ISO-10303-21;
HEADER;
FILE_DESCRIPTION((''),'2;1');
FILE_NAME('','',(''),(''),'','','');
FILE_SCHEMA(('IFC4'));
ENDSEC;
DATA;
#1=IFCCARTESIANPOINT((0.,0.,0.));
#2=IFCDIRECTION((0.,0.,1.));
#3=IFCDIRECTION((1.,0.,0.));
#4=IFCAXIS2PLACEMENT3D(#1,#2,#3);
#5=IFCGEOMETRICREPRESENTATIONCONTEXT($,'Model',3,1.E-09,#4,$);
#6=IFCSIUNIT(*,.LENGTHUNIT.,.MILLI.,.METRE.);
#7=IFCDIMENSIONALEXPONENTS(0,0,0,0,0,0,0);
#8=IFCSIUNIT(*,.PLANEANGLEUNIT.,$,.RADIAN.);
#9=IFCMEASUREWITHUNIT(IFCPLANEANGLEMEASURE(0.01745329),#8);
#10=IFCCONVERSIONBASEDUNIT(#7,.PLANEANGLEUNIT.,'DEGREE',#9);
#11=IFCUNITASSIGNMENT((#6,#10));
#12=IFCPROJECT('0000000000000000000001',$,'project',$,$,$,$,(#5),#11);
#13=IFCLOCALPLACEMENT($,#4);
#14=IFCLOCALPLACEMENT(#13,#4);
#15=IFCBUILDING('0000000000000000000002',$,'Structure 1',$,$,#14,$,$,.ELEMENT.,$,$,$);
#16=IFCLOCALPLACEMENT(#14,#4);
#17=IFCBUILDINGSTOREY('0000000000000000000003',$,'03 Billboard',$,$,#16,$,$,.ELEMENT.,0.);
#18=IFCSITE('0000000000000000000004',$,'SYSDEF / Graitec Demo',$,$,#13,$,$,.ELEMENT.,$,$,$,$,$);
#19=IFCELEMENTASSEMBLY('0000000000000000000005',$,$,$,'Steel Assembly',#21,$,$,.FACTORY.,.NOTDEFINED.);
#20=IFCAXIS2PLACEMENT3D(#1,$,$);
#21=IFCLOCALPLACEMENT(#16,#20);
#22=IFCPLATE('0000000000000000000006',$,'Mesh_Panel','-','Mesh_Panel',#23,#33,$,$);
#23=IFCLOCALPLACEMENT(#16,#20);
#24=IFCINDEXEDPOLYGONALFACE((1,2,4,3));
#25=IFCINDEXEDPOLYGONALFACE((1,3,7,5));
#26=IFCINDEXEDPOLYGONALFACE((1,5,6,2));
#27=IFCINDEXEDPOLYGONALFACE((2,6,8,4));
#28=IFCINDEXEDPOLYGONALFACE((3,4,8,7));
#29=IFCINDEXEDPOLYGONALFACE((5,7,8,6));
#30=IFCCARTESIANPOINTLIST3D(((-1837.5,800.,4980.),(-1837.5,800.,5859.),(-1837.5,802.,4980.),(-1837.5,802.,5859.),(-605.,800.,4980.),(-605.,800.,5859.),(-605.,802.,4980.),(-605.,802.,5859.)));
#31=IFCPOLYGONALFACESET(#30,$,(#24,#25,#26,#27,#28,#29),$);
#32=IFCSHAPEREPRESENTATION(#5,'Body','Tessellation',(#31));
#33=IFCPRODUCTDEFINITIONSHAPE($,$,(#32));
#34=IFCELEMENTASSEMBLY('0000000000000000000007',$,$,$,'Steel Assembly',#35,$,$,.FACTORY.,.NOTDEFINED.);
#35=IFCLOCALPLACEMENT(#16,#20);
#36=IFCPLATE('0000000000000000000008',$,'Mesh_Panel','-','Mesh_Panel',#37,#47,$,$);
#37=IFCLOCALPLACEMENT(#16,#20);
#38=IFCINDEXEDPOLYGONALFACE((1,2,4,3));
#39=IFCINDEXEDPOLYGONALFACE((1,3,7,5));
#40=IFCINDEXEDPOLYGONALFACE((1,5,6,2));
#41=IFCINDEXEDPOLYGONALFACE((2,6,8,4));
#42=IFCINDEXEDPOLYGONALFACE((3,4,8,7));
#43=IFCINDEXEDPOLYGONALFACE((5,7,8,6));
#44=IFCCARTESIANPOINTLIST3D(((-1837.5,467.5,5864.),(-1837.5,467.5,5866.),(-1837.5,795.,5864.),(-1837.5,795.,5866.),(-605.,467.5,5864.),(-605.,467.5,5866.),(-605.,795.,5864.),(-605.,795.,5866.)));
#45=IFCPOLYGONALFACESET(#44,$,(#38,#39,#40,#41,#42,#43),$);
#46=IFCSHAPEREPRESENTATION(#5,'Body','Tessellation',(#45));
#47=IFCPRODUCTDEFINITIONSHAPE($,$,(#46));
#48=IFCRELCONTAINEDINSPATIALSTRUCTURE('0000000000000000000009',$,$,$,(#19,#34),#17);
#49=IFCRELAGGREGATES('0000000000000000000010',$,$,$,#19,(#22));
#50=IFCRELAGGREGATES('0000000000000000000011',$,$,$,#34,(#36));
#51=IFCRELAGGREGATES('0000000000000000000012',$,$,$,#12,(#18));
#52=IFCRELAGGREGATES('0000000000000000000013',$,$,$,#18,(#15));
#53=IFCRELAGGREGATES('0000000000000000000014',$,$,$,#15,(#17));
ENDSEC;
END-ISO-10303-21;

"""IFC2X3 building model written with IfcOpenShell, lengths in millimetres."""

from ifc_helpers import new_model, entity, si_unit, converted_unit, frame, origin_with_axes, place, context, project, spatial, polyline, outline, extrude, element, aggregate, save


model = new_model("IFC2X3")

# Units and contexts
model_context = context("Model", 3, precision=1e-09, world=origin_with_axes())
ifc_project = project(units=[si_unit("LENGTHUNIT", "METRE", prefix="MILLI"), converted_unit("PLANEANGLEUNIT", "DEGREE", entity("IfcPlaneAngleMeasure", 0.01745329), si_unit("PLANEANGLEUNIT", "RADIAN"), dimensions=[0, 0, 0, 0, 0, 0, 0])], contexts=[model_context])

# Site, building, storey
site_placement = place(None, origin_with_axes())
site = spatial("IfcSite", under=ifc_project, at=site_placement, Name="SYSDEF / Graitec Demo", CompositionType="ELEMENT")
building_placement = place(site_placement, origin_with_axes())
building = spatial("IfcBuilding", under=site, at=building_placement, Name="Structure 1", CompositionType="ELEMENT")
storey_placement = place(building_placement, origin_with_axes())
storey = spatial("IfcBuildingStorey", under=building, at=storey_placement, Name="03 Billboard", CompositionType="ELEMENT", Elevation=0.0)

# Element assemblies, plates
assembly_1_placement = place(None, frame((-1221.3, 802.0, 5419.5), z_axis=(0.0, -1.0, 0.0), x_axis=(-1.0, 0.0, 0.0)))
assembly_1 = element("IfcElementAssembly", 1, at=assembly_1_placement, inside=storey, ObjectType="Steel Assembly", AssemblyPlace="FACTORY", PredefinedType="NOTDEFINED")
plate_1_placement = place(assembly_1_placement, origin_with_axes())
plate_1 = element("IfcPlate", 2, at=plate_1_placement, Name="Mesh_Panel", Description="-", ObjectType="Mesh_Panel", context=model_context, shape_type="SweptSolid", body=[
    extrude(outline(polyline([(-616.2, -439.5), (616.2, -439.5), (616.2, 439.5), (-616.2, 439.5), (-616.2, -439.5)])), origin_with_axes(), (0.0, 0.0, 1.0), 2.0),
])
aggregate(assembly_1, [plate_1])
assembly_2_placement = place(None, frame((-1221.2, 631.3, 5866.0), z_axis=(0.0, 0.0, -1.0), x_axis=(-1.0, 0.0, 0.0)))
assembly_2 = element("IfcElementAssembly", 3, at=assembly_2_placement, inside=storey, ObjectType="Steel Assembly", AssemblyPlace="FACTORY", PredefinedType="NOTDEFINED")
plate_2_placement = place(assembly_2_placement, origin_with_axes())
plate_2 = element("IfcPlate", 4, at=plate_2_placement, Name="Mesh_Panel", Description="-", ObjectType="Mesh_Panel", context=model_context, shape_type="SweptSolid", body=[
    extrude(outline(polyline([(-616.2, -163.7), (616.2, -163.7), (616.2, 163.7), (-616.2, 163.7), (-616.2, -163.7)])), origin_with_axes(), (0.0, 0.0, 1.0), 2.0),
])
aggregate(assembly_2, [plate_2])

save(model, "model.ifc")
